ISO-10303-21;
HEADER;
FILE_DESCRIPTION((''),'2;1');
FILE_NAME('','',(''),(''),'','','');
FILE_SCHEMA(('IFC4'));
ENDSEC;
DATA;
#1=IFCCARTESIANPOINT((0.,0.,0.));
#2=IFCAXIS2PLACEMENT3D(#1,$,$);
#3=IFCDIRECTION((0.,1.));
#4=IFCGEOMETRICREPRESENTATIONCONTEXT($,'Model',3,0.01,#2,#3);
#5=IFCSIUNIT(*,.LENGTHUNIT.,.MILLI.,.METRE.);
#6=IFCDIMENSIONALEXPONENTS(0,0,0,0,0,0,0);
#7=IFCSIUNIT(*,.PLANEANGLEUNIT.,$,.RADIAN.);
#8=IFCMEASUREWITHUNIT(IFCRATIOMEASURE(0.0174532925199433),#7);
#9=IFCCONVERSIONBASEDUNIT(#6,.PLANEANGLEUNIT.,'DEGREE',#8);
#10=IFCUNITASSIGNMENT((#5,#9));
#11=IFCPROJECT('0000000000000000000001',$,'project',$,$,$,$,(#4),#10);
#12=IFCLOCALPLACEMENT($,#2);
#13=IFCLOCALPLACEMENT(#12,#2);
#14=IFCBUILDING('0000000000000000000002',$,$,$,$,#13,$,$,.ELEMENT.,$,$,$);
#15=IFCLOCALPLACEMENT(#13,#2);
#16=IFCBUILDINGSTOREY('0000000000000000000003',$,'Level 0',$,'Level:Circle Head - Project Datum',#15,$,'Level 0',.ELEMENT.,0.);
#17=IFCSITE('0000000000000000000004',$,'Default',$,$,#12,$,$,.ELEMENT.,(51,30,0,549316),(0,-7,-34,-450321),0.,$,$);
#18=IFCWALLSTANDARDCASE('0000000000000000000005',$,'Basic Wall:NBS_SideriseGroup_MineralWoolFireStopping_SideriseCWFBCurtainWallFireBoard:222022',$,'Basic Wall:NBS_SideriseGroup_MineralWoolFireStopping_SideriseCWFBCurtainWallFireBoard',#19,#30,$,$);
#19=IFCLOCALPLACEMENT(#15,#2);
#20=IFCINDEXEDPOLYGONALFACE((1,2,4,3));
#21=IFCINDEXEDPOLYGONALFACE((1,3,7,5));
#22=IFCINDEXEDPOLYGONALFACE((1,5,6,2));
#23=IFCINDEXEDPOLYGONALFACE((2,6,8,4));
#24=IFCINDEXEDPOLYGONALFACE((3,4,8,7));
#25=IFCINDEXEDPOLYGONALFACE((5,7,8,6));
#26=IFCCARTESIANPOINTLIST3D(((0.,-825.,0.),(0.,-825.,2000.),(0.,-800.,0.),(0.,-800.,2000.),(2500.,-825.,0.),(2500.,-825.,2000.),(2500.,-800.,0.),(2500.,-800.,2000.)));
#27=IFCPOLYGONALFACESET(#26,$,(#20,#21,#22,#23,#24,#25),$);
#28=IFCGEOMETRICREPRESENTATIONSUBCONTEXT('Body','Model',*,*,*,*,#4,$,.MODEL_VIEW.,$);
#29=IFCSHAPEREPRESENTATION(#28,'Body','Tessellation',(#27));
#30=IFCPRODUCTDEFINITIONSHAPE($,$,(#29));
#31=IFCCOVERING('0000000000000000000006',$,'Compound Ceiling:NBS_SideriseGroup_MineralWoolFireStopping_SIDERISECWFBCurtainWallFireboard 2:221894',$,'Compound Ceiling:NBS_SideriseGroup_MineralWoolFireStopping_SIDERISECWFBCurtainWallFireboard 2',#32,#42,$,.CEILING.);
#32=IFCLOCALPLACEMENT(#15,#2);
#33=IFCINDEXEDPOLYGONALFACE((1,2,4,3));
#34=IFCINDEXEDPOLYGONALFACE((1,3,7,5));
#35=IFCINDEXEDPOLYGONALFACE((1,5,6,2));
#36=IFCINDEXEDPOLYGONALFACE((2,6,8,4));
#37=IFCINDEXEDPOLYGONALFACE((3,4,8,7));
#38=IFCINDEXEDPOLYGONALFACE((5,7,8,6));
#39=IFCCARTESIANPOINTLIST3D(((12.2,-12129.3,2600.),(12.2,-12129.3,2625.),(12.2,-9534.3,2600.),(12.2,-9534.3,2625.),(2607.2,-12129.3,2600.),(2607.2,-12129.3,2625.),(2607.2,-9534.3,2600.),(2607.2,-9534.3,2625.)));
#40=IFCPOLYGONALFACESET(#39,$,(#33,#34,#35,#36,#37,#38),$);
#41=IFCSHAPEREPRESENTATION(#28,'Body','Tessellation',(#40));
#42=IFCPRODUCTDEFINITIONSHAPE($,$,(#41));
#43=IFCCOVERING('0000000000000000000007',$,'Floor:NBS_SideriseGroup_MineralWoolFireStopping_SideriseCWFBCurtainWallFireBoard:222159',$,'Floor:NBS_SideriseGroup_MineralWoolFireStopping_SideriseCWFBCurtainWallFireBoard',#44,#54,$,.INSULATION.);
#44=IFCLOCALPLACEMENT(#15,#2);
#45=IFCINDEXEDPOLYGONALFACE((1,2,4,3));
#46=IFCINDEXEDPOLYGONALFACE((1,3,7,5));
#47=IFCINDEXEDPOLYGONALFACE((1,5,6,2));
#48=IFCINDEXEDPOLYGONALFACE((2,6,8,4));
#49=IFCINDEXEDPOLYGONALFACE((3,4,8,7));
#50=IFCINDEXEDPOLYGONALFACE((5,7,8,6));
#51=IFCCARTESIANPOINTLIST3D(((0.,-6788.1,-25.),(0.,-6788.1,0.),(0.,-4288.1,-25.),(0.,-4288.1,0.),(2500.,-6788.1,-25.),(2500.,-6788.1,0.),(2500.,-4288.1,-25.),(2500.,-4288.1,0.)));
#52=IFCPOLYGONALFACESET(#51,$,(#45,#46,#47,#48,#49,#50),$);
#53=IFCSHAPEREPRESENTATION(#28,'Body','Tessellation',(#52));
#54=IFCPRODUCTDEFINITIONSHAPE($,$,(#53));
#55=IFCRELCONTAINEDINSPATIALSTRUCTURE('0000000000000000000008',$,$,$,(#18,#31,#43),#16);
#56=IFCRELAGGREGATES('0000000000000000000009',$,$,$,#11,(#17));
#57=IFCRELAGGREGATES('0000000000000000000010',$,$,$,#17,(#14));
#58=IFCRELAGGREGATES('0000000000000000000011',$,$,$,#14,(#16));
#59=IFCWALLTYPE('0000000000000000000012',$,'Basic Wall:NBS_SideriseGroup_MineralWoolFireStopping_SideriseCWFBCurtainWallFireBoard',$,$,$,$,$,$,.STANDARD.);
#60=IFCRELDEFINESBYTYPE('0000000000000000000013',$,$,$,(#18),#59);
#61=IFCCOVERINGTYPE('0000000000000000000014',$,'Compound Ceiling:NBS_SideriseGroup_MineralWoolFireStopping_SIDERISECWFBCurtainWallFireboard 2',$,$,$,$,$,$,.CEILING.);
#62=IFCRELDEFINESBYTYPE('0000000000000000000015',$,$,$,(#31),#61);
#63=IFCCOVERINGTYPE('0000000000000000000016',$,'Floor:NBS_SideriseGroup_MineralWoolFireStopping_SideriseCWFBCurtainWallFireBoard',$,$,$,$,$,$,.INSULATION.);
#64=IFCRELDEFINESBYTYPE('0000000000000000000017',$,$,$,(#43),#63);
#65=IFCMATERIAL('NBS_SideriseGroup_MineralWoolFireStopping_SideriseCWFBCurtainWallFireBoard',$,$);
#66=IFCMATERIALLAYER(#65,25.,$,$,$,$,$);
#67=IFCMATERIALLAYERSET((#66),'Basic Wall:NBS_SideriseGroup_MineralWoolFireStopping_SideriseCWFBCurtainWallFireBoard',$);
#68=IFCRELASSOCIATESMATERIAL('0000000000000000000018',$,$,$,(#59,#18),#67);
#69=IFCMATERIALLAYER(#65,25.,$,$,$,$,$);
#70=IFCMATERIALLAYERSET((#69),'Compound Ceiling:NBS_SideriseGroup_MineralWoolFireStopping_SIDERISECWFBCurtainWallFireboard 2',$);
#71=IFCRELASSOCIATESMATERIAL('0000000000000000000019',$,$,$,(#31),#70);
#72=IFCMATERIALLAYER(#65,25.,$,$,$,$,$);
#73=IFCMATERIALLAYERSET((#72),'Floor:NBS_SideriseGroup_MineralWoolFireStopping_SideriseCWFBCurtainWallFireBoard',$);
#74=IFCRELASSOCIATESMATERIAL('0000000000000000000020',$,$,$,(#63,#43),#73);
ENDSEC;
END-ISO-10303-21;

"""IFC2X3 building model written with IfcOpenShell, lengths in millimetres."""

from ifc_helpers import new_model, entity, si_unit, converted_unit, direction, frame, frame_2d, origin, place, context, subcontext, project, spatial, rectangle, extrude, material, layer, layer_set, layer_usage, type_object, element, save


model = new_model("IFC2X3")

# Units and contexts
model_context = context("Model", 3, precision=0.01, world=origin(), true_north=direction((0.0, 1.0)))
body_context = subcontext(model_context, "Body", "Model", "MODEL_VIEW")
ifc_project = project(units=[si_unit("LENGTHUNIT", "METRE", prefix="MILLI"), converted_unit("PLANEANGLEUNIT", "DEGREE", entity("IfcRatioMeasure", 0.0174532925199433), si_unit("PLANEANGLEUNIT", "RADIAN"), dimensions=[0, 0, 0, 0, 0, 0, 0])], contexts=[model_context])

# Site, building, storey
site_placement = place(None, origin())
site = spatial("IfcSite", under=ifc_project, at=site_placement, Name="Default", CompositionType="ELEMENT", RefLatitude=(51, 30, 0, 549316), RefLongitude=(0, -7, -34, -450321), RefElevation=0.0)
building_placement = place(site_placement, origin())
building = spatial("IfcBuilding", under=site, at=building_placement, CompositionType="ELEMENT")
storey_placement = place(building_placement, origin())
storey = spatial("IfcBuildingStorey", under=building, at=storey_placement, Name="Level 0", ObjectType="Level:Circle Head - Project Datum", LongName="Level 0", CompositionType="ELEMENT", Elevation=0.0)

# Wall
ifc_material = material(Name="NBS_SideriseGroup_MineralWoolFireStopping_SideriseCWFBCurtainWallFireBoard")
ifc_layer_1 = layer(ifc_material, 25.0)
ifc_layer_set_1 = layer_set([ifc_layer_1], Name="Basic Wall:NBS_SideriseGroup_MineralWoolFireStopping_SideriseCWFBCurtainWallFireBoard")
ifc_layer_usage_1 = layer_usage(ifc_layer_set_1, "AXIS2", "NEGATIVE", 12.5)
wall_type = type_object("IfcWallType", Name="Basic Wall:NBS_SideriseGroup_MineralWoolFireStopping_SideriseCWFBCurtainWallFireBoard", PredefinedType="STANDARD", material=ifc_layer_set_1)
wall_placement = place(storey_placement, frame((2500.0, -812.5, 0.0), z_axis=(0.0, 0.0, 1.0), x_axis=(-1.0, 0.0, 0.0)))
element("IfcWallStandardCase", 1, at=wall_placement, inside=storey, type_object=wall_type, material=ifc_layer_usage_1, Name="Basic Wall:NBS_SideriseGroup_MineralWoolFireStopping_SideriseCWFBCurtainWallFireBoard:222022", ObjectType="Basic Wall:NBS_SideriseGroup_MineralWoolFireStopping_SideriseCWFBCurtainWallFireBoard", context=body_context, shape_type="SweptSolid", body=[
    extrude(rectangle(XDim=2500.0, YDim=25.0, at=frame_2d((1250.0, 0.0), x_axis=(-1.0, 0.0))), origin(), (0.0, 0.0, 1.0), 2000.0),
])

# Coverings
ifc_layer_2 = layer(ifc_material, 25.0)
ifc_layer_set_2 = layer_set([ifc_layer_2], Name="Compound Ceiling:NBS_SideriseGroup_MineralWoolFireStopping_SIDERISECWFBCurtainWallFireboard 2")
ifc_layer_usage_2 = layer_usage(ifc_layer_set_2, "AXIS3", "POSITIVE", 0.0)
covering_type_1 = type_object("IfcCoveringType", Name="Compound Ceiling:NBS_SideriseGroup_MineralWoolFireStopping_SIDERISECWFBCurtainWallFireboard 2", PredefinedType="CEILING")
covering_1_placement = place(storey_placement, origin())
element("IfcCovering", 2, at=covering_1_placement, inside=storey, type_object=covering_type_1, material=ifc_layer_usage_2, Name="Compound Ceiling:NBS_SideriseGroup_MineralWoolFireStopping_SIDERISECWFBCurtainWallFireboard 2:221894", ObjectType="Compound Ceiling:NBS_SideriseGroup_MineralWoolFireStopping_SIDERISECWFBCurtainWallFireboard 2", PredefinedType="CEILING", context=body_context, shape_type="SweptSolid", body=[
    extrude(rectangle(XDim=2595.0, YDim=2595.0, at=frame_2d((0.0, 0.0), x_axis=(1.0, 0.0))), frame((1309.7, -10831.8, 2600.0), z_axis=(0.0, 0.0, 1.0), x_axis=(0.0, -1.0, 0.0)), (0.0, 0.0, 1.0), 25.0),
])
ifc_layer_3 = layer(ifc_material, 25.0)
ifc_layer_set_3 = layer_set([ifc_layer_3], Name="Floor:NBS_SideriseGroup_MineralWoolFireStopping_SideriseCWFBCurtainWallFireBoard")
ifc_layer_usage_3 = layer_usage(ifc_layer_set_3, "AXIS3", "POSITIVE", 0.0)
covering_type_2 = type_object("IfcCoveringType", Name="Floor:NBS_SideriseGroup_MineralWoolFireStopping_SideriseCWFBCurtainWallFireBoard", PredefinedType="INSULATION", material=ifc_layer_set_3)
covering_2_placement = place(storey_placement, origin())
element("IfcCovering", 3, at=covering_2_placement, inside=storey, type_object=covering_type_2, material=ifc_layer_usage_3, Name="Floor:NBS_SideriseGroup_MineralWoolFireStopping_SideriseCWFBCurtainWallFireBoard:222159", ObjectType="Floor:NBS_SideriseGroup_MineralWoolFireStopping_SideriseCWFBCurtainWallFireBoard", PredefinedType="INSULATION", context=body_context, shape_type="SweptSolid", body=[
    extrude(rectangle(XDim=2500.0, YDim=2500.0, at=frame_2d((0.0, 0.0), x_axis=(1.0, 0.0))), frame((1250.0, -5538.1, 0.0), z_axis=(0.0, 0.0, -1.0), x_axis=(0.0, 1.0, 0.0)), (0.0, 0.0, 1.0), 25.0),
])

save(model, "model.ifc")
